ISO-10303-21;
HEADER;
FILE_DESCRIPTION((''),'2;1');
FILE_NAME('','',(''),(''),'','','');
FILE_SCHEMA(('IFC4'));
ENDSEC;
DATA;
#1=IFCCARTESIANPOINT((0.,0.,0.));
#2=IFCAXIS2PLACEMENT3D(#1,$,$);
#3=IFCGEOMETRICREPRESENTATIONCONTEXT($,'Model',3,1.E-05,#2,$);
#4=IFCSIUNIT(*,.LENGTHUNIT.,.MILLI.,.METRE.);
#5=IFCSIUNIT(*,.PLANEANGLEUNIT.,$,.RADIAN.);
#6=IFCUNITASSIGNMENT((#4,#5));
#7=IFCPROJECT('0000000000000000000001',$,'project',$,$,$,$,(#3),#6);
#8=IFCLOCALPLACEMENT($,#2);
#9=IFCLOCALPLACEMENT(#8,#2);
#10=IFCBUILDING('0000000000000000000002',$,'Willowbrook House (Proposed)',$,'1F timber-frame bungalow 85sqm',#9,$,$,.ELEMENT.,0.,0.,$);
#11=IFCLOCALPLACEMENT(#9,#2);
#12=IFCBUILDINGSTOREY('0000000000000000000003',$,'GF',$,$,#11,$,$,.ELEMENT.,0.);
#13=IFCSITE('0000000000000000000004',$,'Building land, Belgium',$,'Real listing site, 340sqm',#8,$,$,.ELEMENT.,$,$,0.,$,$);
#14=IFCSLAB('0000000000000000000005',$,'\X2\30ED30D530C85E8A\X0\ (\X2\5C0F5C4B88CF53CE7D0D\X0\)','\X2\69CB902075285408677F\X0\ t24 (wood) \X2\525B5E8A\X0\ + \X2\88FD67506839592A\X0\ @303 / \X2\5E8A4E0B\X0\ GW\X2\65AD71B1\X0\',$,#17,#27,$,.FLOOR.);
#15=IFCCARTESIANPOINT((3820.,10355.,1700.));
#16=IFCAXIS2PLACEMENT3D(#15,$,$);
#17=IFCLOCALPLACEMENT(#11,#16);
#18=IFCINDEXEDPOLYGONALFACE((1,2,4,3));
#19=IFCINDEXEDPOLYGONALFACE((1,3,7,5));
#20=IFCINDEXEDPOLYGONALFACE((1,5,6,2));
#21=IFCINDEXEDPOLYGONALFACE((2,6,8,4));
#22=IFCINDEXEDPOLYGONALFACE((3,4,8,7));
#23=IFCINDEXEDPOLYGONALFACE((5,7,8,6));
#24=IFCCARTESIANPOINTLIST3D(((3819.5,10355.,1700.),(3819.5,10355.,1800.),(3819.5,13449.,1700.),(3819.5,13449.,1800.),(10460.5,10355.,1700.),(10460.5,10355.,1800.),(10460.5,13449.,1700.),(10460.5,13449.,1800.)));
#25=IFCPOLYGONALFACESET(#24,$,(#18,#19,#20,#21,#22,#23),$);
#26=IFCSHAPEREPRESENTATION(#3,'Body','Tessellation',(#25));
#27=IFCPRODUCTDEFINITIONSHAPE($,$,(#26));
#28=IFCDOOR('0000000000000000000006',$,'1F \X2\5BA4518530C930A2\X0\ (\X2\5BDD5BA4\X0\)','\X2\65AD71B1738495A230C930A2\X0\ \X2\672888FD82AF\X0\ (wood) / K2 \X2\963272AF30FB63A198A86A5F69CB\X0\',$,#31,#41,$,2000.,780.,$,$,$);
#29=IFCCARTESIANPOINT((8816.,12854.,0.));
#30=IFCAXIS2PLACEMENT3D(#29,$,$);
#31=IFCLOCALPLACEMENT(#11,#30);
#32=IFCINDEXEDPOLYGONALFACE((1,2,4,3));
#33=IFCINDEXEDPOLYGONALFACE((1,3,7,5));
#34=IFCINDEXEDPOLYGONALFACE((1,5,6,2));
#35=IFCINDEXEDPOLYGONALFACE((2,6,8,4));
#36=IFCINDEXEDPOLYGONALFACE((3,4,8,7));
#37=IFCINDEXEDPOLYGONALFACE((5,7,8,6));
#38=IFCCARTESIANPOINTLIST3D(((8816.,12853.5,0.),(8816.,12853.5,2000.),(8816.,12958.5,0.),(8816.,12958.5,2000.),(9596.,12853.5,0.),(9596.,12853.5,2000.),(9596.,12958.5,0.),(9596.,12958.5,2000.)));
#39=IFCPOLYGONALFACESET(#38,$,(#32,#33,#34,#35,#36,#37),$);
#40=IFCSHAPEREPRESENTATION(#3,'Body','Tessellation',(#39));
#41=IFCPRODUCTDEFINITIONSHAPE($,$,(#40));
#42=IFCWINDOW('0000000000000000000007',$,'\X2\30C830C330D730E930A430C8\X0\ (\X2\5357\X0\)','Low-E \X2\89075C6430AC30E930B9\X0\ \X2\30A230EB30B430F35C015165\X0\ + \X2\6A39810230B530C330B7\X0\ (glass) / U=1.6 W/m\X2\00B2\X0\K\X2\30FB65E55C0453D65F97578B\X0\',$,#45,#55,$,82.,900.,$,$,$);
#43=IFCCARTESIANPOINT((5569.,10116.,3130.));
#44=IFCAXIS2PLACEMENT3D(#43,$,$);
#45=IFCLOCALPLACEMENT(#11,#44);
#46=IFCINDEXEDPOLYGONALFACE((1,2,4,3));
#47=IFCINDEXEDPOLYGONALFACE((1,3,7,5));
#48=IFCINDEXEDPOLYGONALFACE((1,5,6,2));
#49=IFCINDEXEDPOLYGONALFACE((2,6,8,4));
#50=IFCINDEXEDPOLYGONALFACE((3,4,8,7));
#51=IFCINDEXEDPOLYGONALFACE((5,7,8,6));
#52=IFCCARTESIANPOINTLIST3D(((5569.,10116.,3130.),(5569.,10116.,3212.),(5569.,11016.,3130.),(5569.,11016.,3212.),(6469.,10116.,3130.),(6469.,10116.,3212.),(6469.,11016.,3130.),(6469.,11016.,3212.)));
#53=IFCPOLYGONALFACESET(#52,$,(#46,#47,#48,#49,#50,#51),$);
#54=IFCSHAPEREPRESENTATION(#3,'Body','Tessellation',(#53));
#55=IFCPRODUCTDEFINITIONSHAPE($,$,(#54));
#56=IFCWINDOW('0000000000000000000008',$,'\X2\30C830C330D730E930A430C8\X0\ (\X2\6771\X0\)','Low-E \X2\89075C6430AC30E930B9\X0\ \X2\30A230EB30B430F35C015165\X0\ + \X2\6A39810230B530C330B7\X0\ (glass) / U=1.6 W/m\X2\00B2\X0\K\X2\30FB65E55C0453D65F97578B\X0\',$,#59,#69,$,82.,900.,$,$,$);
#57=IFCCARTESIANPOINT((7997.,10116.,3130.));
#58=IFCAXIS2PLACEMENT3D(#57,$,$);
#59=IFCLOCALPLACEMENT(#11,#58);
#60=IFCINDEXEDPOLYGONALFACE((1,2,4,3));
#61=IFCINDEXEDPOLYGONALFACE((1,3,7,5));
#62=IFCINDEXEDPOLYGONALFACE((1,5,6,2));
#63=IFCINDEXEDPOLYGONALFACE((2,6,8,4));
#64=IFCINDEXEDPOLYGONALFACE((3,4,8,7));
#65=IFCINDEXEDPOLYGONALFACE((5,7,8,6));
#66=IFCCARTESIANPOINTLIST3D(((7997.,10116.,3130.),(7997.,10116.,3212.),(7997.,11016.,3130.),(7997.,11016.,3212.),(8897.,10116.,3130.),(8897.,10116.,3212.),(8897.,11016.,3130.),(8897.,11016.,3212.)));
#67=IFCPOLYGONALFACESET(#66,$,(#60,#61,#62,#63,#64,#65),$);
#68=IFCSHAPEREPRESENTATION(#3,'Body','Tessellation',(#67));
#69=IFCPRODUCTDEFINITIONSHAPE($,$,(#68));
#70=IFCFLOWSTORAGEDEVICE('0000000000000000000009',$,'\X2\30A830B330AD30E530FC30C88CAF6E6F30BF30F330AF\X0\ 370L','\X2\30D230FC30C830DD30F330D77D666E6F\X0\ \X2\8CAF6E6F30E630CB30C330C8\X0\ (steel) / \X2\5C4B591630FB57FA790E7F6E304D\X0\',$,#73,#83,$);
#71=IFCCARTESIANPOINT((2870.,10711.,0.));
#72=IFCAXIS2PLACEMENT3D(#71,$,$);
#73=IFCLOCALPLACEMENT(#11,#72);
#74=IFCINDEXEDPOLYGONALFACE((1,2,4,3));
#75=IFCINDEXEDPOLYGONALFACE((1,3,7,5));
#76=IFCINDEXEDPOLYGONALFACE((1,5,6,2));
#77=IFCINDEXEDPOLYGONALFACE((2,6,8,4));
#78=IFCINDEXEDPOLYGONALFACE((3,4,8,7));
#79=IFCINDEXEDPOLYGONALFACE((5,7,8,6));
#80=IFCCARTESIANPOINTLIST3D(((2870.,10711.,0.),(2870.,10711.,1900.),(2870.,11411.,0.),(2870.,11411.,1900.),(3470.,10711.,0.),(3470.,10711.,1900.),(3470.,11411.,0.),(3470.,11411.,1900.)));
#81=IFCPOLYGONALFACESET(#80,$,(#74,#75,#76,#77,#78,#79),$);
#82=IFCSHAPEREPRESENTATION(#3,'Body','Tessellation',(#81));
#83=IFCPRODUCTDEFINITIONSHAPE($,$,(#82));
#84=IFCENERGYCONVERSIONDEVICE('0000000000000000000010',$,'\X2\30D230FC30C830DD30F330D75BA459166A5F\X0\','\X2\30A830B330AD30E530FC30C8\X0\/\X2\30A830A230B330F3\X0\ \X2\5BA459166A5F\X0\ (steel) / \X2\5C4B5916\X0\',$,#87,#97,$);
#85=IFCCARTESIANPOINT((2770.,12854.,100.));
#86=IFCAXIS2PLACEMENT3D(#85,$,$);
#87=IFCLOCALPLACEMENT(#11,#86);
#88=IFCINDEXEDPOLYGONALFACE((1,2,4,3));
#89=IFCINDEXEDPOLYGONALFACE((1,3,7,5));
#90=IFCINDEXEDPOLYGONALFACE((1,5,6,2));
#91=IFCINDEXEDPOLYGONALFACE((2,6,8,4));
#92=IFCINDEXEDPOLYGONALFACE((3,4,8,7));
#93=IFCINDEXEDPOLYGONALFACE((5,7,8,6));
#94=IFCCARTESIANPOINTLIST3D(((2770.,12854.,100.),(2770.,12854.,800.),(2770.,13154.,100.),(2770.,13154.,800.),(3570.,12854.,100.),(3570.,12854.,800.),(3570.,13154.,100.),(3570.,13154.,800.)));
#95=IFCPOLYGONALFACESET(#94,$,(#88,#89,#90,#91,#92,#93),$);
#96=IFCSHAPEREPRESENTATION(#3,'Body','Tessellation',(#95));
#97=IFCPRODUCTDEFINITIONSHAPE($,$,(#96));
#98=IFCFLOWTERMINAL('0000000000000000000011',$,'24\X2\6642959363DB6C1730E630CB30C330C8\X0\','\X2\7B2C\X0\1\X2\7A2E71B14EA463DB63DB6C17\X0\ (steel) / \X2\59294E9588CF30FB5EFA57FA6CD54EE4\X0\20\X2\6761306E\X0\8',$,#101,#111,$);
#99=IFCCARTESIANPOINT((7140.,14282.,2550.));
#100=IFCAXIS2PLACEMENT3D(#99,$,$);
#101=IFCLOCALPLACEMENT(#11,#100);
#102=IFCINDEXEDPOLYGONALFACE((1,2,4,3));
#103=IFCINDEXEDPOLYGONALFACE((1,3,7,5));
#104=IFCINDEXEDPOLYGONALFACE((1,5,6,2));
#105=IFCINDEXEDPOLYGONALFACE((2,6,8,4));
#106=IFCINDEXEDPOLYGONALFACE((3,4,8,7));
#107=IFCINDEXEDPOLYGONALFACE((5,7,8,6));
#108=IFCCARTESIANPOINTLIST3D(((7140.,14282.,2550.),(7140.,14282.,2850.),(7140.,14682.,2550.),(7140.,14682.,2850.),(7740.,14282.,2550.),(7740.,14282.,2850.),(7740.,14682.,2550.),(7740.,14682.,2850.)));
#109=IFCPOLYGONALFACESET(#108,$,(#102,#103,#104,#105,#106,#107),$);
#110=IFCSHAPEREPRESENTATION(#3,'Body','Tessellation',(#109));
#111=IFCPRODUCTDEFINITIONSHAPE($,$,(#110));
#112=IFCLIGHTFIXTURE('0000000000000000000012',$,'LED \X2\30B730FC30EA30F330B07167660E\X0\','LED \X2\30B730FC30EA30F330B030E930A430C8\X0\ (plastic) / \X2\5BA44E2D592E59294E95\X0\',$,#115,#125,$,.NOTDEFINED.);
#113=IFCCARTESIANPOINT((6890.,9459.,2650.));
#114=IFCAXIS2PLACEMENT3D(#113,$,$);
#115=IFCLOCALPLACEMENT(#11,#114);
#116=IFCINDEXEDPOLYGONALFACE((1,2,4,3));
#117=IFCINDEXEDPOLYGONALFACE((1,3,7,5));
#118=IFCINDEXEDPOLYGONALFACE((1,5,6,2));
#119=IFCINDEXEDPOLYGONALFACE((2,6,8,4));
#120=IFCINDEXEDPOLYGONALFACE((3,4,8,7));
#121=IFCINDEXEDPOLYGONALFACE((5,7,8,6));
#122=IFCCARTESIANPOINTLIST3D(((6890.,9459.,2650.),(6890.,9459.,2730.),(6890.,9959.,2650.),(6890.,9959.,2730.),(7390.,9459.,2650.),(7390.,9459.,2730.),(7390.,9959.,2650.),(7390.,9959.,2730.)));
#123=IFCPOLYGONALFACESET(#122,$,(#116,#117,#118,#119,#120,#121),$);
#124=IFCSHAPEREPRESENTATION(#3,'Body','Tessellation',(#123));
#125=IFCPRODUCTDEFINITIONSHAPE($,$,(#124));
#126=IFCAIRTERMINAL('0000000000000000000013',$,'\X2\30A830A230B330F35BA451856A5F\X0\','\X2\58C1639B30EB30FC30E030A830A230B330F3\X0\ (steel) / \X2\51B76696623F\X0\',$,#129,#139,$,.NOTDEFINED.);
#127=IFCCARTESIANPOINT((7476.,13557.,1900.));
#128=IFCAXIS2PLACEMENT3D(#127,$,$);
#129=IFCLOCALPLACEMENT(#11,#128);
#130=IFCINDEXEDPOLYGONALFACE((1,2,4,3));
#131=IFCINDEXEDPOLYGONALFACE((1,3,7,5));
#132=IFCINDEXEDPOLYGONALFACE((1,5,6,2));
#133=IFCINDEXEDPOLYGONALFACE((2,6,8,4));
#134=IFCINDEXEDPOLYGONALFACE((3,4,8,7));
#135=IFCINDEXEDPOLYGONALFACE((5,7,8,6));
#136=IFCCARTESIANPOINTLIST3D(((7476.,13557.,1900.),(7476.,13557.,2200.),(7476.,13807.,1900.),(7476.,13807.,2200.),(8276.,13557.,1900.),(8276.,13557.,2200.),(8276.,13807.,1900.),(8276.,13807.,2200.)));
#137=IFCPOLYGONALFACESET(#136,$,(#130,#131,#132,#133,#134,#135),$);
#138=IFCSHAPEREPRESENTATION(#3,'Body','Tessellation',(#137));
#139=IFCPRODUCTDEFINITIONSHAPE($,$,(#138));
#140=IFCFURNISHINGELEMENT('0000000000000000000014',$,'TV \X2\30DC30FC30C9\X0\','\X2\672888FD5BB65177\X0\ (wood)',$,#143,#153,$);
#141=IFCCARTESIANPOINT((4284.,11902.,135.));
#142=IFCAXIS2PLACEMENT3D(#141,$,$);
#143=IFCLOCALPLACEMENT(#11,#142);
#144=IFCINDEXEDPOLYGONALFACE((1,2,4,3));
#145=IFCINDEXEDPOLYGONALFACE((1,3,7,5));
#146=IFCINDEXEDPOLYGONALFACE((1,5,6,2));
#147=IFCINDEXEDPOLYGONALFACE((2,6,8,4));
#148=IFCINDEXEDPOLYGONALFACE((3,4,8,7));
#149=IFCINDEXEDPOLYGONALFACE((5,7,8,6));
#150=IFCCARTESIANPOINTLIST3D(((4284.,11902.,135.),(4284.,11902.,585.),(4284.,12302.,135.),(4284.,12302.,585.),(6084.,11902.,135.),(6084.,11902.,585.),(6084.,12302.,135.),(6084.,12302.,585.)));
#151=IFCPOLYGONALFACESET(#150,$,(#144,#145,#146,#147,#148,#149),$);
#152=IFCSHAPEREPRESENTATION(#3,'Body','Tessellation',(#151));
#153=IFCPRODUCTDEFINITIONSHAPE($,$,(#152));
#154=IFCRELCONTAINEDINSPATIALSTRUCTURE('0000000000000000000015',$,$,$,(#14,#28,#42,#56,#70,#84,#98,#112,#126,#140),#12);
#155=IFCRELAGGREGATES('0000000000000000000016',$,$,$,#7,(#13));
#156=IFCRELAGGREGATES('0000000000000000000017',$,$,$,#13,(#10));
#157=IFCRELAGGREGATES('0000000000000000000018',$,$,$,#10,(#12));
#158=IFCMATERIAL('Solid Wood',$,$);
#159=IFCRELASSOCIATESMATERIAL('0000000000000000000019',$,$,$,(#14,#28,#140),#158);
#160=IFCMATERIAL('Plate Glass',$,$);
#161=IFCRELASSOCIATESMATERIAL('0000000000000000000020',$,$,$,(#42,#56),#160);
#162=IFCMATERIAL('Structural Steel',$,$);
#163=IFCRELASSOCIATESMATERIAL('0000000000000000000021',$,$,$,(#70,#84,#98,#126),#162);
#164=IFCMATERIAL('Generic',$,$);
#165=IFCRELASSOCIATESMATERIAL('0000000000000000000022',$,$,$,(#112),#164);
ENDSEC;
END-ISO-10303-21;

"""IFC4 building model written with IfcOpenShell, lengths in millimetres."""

from ifc_helpers import new_model, si_unit, frame, frame_2d, origin, place, context, project, spatial, rectangle, extrude, material, element, save


model = new_model("IFC4")

# Units and contexts
model_context = context("Model", 3, precision=1e-05, world=origin())
ifc_project = project(units=[si_unit("LENGTHUNIT", "METRE", prefix="MILLI"), si_unit("PLANEANGLEUNIT", "RADIAN")], contexts=[model_context])

# Site, building, storey
site_placement = place(None, origin())
site = spatial("IfcSite", under=ifc_project, at=site_placement, Name="Building land, Belgium", ObjectType="Real listing site, 340sqm", CompositionType="ELEMENT", RefElevation=0.0)
building_placement = place(site_placement, origin())
building = spatial("IfcBuilding", under=site, at=building_placement, Name="Willowbrook House (Proposed)", ObjectType="1F timber-frame bungalow 85sqm", CompositionType="ELEMENT", ElevationOfRefHeight=0.0, ElevationOfTerrain=0.0)
storey_placement = place(building_placement, origin())
storey = spatial("IfcBuildingStorey", under=building, at=storey_placement, Name="GF", CompositionType="ELEMENT", Elevation=0.0)

# Shared definitions
ifc_material_1 = material(Name="Solid Wood")

# Slab
slab_placement = place(storey_placement, frame((3820.0, 10355.0, 1700.0)))
element("IfcSlab", 1, at=slab_placement, inside=storey, material=ifc_material_1, Name="ロフト床 (小屋裏収納)", Description="構造用合板 t24 (wood) 剛床 + 製材根太 @303 / 床下 GW断熱", PredefinedType="FLOOR", context=model_context, shape_type="SweptSolid", body=[
    extrude(rectangle(XDim=6641.0, YDim=3094.0, at=frame_2d((3320.0, 1547.0))), frame((3820.0, 10355.0, 1700.0)), (0.0, 0.0, 1.0), 100.0),
])

# Door
door_1_placement = place(storey_placement, frame((8816.0, 12854.0, 0.0)))
element("IfcDoor", 2, at=door_1_placement, inside=storey, material=ifc_material_1, Name="1F 室内ドア (寝室)", Description="断熱玄関ドア 木製芯 (wood) / K2 防犯・採風機構", OverallHeight=2000.0, OverallWidth=780.0, context=model_context, shape_type="SweptSolid", body=[
    extrude(rectangle(XDim=780.0, YDim=105.0, at=frame_2d((390.0, 52.0))), frame((8816.0, 12854.0, 0.0)), (0.0, 0.0, 1.0), 2000.0),
])

# Windows
ifc_material_2 = material(Name="Plate Glass")
window_1_placement = place(storey_placement, frame((5569.0, 10116.0, 3130.0)))
element("IfcWindow", 3, at=window_1_placement, inside=storey, material=ifc_material_2, Name="トップライト (南)", Description="Low-E 複層ガラス アルゴン封入 + 樹脂サッシ (glass) / U=1.6 W/m²K・日射取得型", OverallHeight=82.0, OverallWidth=900.0, context=model_context, shape_type="SweptSolid", body=[
    extrude(rectangle(XDim=900.0, YDim=900.0, at=frame_2d((450.0, 450.0))), frame((5569.0, 10116.0, 3130.0)), (0.0, 0.0, 1.0), 82.0),
])
window_2_placement = place(storey_placement, frame((7997.0, 10116.0, 3130.0)))
element("IfcWindow", 4, at=window_2_placement, inside=storey, material=ifc_material_2, Name="トップライト (東)", Description="Low-E 複層ガラス アルゴン封入 + 樹脂サッシ (glass) / U=1.6 W/m²K・日射取得型", OverallHeight=82.0, OverallWidth=900.0, context=model_context, shape_type="SweptSolid", body=[
    extrude(rectangle(XDim=900.0, YDim=900.0, at=frame_2d((450.0, 450.0))), frame((7997.0, 10116.0, 3130.0)), (0.0, 0.0, 1.0), 82.0),
])

# Flow storage device
ifc_material_3 = material(Name="Structural Steel")
flow_storage_device_placement = place(storey_placement, frame((2870.0, 10711.0, 0.0)))
element("IfcFlowStorageDevice", 5, at=flow_storage_device_placement, inside=storey, material=ifc_material_3, Name="エコキュート貯湯タンク 370L", Description="ヒートポンプ給湯 貯湯ユニット (steel) / 屋外・基礎置き", context=model_context, shape_type="SweptSolid", body=[
    extrude(rectangle(XDim=600.0, YDim=700.0, at=frame_2d((300.0, 350.0))), frame((2870.0, 10711.0, 0.0)), (0.0, 0.0, 1.0), 1900.0),
])

# Energy conversion device
energy_conversion_device_placement = place(storey_placement, frame((2770.0, 12854.0, 100.0)))
element("IfcEnergyConversionDevice", 6, at=energy_conversion_device_placement, inside=storey, material=ifc_material_3, Name="ヒートポンプ室外機", Description="エコキュート/エアコン 室外機 (steel) / 屋外", context=model_context, shape_type="SweptSolid", body=[
    extrude(rectangle(XDim=800.0, YDim=300.0, at=frame_2d((400.0, 150.0))), frame((2770.0, 12854.0, 100.0)), (0.0, 0.0, 1.0), 700.0),
])

# Flow terminal
flow_terminal_placement = place(storey_placement, frame((7140.0, 14282.0, 2550.0)))
element("IfcFlowTerminal", 7, at=flow_terminal_placement, inside=storey, material=ifc_material_3, Name="24時間換気ユニット", Description="第1種熱交換換気 (steel) / 天井裏・建基法令20条の8", context=model_context, shape_type="SweptSolid", body=[
    extrude(rectangle(XDim=600.0, YDim=400.0, at=frame_2d((300.0, 200.0))), frame((7140.0, 14282.0, 2550.0)), (0.0, 0.0, 1.0), 300.0),
])

# Light fixture
ifc_material_4 = material(Name="Generic")
light_fixture_placement = place(storey_placement, frame((6890.0, 9459.0, 2650.0)))
element("IfcLightFixture", 8, at=light_fixture_placement, inside=storey, material=ifc_material_4, Name="LED シーリング照明", Description="LED シーリングライト (plastic) / 室中央天井", PredefinedType="NOTDEFINED", context=model_context, shape_type="SweptSolid", body=[
    extrude(rectangle(XDim=500.0, YDim=500.0, at=frame_2d((250.0, 250.0))), frame((6890.0, 9459.0, 2650.0)), (0.0, 0.0, 1.0), 80.0),
])

# Air terminal
air_terminal_placement = place(storey_placement, frame((7476.0, 13557.0, 1900.0)))
element("IfcAirTerminal", 9, at=air_terminal_placement, inside=storey, material=ifc_material_3, Name="エアコン室内機", Description="壁掛ルームエアコン (steel) / 冷暖房", PredefinedType="NOTDEFINED", context=model_context, shape_type="SweptSolid", body=[
    extrude(rectangle(XDim=800.0, YDim=250.0, at=frame_2d((400.0, 125.0))), frame((7476.0, 13557.0, 1900.0)), (0.0, 0.0, 1.0), 300.0),
])

# Furnishing element
furnishing_placement = place(storey_placement, frame((4284.0, 11902.0, 135.0)))
element("IfcFurnishingElement", 10, at=furnishing_placement, inside=storey, material=ifc_material_1, Name="TV ボード", Description="木製家具 (wood)", context=model_context, shape_type="SweptSolid", body=[
    extrude(rectangle(XDim=1800.0, YDim=400.0, at=frame_2d((900.0, 200.0))), frame((4284.0, 11902.0, 135.0)), (0.0, 0.0, 1.0), 450.0),
])

save(model, "model.ifc")
